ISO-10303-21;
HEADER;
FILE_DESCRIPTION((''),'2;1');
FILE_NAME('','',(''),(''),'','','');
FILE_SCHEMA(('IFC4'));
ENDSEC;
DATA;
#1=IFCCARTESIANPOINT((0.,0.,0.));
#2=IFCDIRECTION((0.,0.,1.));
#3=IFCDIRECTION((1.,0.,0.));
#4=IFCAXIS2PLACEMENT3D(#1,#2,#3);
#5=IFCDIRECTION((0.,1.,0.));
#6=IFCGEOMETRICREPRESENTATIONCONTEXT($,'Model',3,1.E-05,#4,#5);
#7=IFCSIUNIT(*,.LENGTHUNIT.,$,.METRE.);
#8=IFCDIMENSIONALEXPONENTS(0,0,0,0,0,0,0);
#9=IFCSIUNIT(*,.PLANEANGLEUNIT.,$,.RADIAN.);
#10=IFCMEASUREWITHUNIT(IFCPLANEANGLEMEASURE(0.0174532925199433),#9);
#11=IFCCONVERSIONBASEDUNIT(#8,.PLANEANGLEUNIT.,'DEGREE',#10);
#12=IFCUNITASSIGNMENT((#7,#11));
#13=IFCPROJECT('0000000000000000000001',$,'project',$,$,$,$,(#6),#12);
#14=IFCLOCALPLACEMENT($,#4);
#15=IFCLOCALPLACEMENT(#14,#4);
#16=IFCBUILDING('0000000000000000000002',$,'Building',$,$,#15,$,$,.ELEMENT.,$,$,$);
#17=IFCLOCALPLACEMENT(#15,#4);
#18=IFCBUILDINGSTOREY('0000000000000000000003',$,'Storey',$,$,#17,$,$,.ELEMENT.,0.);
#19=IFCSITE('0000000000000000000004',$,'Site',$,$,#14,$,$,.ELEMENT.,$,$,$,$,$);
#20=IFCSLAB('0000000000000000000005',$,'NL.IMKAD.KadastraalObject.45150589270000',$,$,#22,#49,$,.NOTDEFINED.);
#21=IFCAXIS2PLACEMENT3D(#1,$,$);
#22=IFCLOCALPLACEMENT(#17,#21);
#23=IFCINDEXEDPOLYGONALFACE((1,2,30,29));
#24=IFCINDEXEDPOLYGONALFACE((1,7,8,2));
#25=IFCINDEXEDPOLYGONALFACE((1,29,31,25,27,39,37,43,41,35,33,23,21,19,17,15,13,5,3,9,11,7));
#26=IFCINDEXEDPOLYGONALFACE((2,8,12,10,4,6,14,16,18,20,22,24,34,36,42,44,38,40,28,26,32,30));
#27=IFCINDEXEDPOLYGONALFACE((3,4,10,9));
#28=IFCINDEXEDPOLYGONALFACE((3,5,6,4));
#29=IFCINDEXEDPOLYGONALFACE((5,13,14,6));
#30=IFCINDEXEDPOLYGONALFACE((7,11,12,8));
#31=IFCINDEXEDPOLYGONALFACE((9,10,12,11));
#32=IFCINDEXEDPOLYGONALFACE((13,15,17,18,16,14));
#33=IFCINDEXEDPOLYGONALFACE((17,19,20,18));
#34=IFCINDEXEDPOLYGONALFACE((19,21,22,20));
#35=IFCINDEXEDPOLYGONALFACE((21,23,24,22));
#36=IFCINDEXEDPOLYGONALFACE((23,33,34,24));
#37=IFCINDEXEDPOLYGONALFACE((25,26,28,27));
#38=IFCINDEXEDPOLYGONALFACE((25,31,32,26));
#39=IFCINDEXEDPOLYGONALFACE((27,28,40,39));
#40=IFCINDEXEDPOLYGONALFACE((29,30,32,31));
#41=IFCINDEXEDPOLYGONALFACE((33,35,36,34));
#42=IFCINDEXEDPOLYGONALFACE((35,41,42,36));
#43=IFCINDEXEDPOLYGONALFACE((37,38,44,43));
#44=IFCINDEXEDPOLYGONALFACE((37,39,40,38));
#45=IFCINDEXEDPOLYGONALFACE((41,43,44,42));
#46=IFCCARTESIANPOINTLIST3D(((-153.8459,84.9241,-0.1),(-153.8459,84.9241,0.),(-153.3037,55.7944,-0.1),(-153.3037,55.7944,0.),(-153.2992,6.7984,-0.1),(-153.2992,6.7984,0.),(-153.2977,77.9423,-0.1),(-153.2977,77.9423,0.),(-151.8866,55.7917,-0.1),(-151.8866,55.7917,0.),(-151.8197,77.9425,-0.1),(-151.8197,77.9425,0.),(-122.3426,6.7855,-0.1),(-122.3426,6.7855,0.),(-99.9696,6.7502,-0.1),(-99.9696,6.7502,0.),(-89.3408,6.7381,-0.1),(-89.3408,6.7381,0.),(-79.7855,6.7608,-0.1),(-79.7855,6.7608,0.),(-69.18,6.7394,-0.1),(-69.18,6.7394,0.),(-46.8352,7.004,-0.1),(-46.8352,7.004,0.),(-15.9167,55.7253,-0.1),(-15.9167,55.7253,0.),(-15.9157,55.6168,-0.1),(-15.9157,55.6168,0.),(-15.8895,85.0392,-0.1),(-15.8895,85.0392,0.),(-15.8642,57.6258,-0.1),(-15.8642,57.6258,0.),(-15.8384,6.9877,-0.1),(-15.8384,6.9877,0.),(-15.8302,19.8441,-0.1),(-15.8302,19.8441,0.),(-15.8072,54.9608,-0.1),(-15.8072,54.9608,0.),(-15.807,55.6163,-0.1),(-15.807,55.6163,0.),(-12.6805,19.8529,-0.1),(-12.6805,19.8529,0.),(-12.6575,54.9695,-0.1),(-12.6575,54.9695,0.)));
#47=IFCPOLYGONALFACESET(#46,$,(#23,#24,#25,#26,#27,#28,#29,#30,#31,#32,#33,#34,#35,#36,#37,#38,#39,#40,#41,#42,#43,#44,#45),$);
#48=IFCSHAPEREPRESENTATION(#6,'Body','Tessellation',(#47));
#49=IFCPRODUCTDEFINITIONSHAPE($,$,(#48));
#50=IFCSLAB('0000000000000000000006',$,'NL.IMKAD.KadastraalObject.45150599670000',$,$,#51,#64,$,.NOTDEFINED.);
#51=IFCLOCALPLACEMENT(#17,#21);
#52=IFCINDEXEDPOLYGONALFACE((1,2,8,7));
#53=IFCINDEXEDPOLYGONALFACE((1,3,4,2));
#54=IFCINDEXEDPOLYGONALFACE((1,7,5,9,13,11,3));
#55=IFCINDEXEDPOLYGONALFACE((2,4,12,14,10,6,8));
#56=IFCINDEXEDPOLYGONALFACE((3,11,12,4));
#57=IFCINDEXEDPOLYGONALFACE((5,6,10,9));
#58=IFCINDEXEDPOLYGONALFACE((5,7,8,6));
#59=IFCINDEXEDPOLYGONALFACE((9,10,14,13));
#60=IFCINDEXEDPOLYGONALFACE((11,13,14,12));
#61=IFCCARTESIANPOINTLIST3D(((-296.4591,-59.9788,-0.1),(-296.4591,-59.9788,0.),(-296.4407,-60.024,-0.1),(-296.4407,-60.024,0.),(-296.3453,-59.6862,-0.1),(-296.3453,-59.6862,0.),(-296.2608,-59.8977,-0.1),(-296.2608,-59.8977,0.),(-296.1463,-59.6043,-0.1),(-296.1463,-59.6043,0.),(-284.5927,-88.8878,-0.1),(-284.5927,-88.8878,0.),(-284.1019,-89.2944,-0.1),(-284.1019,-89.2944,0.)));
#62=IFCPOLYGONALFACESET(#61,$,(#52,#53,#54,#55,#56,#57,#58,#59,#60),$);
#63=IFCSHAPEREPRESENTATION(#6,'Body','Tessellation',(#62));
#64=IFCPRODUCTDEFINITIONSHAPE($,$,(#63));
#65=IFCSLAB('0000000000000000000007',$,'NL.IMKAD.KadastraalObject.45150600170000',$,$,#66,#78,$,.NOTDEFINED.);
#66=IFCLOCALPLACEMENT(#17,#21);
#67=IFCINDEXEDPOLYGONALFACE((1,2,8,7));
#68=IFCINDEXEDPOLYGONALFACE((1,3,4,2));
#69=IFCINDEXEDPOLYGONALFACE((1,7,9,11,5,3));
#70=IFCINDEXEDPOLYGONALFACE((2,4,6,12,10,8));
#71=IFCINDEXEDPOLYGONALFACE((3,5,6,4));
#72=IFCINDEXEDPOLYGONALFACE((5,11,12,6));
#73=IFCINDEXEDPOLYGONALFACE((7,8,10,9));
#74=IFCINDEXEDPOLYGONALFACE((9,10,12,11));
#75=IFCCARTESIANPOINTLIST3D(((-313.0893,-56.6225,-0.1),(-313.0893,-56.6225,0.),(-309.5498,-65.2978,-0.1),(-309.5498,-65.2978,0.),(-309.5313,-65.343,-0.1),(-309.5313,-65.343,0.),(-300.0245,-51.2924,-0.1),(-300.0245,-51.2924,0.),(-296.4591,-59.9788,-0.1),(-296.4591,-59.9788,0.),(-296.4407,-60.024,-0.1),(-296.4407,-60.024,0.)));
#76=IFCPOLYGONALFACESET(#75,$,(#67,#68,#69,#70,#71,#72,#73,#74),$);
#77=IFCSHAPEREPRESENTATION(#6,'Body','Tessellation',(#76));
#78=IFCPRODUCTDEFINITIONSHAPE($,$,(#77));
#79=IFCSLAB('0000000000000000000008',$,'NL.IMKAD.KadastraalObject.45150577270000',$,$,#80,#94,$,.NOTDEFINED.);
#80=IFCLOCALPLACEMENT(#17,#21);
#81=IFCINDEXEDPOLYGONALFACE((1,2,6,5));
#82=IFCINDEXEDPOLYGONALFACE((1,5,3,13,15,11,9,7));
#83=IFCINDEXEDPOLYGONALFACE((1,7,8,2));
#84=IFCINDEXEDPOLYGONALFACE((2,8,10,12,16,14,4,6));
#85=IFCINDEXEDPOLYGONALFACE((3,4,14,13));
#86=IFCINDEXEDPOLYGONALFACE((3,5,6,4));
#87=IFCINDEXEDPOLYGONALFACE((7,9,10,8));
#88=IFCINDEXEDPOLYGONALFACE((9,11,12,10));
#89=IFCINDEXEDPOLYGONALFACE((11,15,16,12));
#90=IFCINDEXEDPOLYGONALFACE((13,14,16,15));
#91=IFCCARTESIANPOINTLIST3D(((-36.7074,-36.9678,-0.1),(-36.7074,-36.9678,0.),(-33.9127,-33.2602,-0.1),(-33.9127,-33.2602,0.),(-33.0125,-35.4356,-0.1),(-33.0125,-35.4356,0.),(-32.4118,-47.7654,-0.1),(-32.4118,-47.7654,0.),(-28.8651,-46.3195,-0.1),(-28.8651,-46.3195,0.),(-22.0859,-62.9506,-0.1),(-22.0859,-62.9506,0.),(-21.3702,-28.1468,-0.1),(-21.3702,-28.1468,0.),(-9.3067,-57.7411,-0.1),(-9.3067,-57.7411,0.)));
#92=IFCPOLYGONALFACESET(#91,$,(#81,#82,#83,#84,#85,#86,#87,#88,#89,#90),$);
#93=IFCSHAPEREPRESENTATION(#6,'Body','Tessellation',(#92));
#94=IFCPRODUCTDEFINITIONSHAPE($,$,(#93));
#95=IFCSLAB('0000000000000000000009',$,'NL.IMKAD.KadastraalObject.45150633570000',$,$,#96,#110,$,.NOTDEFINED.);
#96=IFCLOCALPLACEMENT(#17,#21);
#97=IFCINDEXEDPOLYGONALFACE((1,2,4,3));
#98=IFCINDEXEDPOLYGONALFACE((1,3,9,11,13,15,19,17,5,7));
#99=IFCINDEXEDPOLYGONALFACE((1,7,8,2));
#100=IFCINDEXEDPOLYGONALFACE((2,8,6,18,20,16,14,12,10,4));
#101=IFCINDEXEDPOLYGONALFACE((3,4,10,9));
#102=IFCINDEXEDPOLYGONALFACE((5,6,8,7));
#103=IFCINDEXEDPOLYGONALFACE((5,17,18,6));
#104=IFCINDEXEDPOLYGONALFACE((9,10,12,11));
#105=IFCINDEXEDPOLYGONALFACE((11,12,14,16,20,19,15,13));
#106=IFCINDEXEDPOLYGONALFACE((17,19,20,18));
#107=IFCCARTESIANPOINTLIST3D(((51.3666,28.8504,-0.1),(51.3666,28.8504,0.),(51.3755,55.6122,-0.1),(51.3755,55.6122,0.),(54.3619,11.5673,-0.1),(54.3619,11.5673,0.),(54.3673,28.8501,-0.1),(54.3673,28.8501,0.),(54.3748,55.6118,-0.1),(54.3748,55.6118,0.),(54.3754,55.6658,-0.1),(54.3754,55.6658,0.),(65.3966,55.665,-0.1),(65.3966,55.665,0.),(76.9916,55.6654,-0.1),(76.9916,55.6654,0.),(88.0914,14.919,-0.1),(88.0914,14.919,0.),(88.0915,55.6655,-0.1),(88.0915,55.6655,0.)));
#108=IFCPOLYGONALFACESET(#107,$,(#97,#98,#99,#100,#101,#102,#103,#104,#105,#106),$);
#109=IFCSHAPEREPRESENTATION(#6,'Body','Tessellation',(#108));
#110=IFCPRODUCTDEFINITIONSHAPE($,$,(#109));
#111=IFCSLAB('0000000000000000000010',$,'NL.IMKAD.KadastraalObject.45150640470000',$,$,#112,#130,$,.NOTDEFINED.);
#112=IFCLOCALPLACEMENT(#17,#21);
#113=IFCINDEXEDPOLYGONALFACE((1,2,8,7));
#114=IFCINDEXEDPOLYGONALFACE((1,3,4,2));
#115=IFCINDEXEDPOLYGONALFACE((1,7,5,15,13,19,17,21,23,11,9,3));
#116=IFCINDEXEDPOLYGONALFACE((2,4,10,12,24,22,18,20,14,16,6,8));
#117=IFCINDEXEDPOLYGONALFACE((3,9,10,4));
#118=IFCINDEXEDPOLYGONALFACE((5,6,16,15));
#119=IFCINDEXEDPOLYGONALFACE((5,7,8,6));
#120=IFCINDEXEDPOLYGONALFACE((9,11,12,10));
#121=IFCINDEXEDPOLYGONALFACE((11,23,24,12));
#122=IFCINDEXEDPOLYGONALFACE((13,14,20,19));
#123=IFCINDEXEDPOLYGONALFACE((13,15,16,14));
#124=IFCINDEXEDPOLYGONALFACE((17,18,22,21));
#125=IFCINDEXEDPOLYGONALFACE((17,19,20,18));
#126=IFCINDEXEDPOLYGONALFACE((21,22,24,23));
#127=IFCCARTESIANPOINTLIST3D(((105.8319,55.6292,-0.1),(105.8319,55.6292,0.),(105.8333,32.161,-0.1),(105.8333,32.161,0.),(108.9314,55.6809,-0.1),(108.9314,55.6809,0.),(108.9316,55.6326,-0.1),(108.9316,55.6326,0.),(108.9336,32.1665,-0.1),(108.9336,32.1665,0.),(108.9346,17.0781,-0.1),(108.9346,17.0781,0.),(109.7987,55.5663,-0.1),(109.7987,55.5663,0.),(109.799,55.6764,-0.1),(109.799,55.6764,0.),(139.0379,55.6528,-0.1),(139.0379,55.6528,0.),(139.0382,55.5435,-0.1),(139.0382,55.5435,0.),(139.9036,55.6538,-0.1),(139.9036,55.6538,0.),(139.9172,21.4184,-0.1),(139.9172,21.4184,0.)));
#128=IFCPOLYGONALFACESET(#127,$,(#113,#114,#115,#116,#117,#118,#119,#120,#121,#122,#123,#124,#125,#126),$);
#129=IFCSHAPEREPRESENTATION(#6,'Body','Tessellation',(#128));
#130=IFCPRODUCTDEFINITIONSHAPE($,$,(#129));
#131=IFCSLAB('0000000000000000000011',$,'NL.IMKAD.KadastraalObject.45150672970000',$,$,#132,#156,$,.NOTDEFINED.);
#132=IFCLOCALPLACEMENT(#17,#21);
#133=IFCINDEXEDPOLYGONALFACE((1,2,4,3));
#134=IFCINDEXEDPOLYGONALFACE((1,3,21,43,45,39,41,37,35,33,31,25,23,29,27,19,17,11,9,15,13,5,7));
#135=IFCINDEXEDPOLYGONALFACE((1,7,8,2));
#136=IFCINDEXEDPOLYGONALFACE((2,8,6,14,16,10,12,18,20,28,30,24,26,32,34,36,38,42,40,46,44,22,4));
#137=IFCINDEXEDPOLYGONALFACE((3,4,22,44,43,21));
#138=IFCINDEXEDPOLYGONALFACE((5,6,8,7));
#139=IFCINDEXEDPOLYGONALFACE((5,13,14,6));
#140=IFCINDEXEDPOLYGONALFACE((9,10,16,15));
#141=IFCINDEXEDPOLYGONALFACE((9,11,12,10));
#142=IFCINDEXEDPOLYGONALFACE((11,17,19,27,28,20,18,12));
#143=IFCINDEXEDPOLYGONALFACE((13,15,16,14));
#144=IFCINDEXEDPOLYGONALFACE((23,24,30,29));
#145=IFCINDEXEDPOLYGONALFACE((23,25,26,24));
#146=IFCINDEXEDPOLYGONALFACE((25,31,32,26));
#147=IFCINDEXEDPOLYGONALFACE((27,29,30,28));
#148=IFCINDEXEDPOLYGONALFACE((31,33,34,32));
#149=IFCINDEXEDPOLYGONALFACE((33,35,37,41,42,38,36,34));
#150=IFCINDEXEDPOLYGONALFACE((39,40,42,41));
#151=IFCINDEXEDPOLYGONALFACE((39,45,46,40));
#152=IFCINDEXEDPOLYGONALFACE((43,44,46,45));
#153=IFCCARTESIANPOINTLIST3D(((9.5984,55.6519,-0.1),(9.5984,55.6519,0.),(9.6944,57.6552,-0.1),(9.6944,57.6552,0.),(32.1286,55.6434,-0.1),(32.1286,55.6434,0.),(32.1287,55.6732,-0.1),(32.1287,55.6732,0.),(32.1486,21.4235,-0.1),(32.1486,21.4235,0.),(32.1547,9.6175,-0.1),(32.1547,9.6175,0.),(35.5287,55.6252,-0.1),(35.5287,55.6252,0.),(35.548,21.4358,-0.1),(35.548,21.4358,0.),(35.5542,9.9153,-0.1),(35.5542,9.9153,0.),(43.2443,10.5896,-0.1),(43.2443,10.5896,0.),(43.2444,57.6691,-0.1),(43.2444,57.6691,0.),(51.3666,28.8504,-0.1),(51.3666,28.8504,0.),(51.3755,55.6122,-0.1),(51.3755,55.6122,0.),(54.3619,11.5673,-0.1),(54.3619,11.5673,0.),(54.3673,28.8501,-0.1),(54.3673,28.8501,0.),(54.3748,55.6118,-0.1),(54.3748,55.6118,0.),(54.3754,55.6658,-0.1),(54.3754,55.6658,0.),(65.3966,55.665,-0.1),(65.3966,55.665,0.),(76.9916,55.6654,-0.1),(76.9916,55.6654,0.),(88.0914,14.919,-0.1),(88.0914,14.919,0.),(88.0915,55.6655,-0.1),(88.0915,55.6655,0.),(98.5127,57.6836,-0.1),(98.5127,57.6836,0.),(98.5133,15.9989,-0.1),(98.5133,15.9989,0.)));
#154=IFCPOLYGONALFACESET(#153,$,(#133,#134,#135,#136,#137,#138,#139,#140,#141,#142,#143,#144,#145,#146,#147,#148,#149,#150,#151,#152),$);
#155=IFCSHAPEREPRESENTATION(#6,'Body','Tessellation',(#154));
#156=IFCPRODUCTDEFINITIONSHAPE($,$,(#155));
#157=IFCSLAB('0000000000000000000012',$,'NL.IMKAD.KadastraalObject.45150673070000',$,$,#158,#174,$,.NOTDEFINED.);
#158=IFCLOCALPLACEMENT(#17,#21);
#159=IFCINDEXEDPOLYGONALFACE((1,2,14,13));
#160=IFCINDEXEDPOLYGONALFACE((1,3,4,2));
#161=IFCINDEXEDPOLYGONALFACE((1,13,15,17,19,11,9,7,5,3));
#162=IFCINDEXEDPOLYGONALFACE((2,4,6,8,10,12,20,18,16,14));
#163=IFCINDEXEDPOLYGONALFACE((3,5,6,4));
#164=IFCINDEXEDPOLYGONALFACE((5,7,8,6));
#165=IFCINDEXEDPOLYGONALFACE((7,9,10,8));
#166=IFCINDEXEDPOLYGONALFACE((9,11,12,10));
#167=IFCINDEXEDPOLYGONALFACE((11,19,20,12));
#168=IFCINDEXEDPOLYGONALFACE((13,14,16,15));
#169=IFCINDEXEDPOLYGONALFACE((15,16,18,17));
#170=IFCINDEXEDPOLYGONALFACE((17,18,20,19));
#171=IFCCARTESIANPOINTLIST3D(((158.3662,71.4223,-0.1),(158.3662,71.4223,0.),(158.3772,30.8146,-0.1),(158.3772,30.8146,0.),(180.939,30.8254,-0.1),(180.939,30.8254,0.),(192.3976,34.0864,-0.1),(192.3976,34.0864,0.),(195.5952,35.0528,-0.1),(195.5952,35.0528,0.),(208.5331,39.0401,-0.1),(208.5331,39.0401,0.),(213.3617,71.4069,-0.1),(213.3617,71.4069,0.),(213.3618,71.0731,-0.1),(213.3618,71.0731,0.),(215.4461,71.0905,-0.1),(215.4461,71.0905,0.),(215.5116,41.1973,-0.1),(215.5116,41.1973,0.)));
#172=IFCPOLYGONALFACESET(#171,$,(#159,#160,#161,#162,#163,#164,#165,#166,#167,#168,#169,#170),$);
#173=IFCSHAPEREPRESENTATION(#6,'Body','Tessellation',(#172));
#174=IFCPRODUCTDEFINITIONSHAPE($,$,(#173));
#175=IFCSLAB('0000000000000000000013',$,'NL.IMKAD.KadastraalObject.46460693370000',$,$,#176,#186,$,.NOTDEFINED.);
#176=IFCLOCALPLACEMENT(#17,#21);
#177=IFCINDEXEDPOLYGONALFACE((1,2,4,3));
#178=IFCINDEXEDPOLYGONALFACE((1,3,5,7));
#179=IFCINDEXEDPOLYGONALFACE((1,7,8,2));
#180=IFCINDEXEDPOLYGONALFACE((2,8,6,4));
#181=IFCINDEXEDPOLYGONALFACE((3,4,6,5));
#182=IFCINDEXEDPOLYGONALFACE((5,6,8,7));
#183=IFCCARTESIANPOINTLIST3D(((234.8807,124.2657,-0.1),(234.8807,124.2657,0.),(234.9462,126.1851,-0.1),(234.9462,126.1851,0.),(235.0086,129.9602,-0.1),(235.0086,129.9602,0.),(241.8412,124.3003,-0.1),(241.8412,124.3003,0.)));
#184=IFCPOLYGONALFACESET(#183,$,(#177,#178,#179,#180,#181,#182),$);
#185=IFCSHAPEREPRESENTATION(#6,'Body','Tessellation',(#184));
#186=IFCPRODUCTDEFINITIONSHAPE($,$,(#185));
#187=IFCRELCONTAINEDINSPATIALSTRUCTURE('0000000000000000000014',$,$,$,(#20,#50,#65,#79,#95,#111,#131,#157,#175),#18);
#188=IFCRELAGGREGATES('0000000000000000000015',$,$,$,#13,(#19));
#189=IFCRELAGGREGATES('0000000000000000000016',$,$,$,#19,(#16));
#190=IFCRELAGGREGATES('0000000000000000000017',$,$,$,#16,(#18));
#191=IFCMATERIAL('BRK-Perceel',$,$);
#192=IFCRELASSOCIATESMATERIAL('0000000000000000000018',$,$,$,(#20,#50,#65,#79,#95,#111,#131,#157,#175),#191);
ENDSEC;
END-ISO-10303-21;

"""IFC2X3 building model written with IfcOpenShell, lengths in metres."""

from ifc_helpers import new_model, entity, si_unit, converted_unit, direction, frame, origin_with_axes, place, context, project, spatial, polyline, outline, extrude, material, element, save


model = new_model("IFC2X3")

# Units and contexts
model_context = context("Model", 3, precision=1e-05, world=origin_with_axes(), true_north=direction((0.0, 1.0, 0.0)))
ifc_project = project(units=[si_unit("LENGTHUNIT", "METRE"), converted_unit("PLANEANGLEUNIT", "DEGREE", entity("IfcPlaneAngleMeasure", 0.0174532925199433), si_unit("PLANEANGLEUNIT", "RADIAN"), dimensions=[0, 0, 0, 0, 0, 0, 0])], contexts=[model_context])

# Site, building, storey
site_placement = place(None, origin_with_axes())
site = spatial("IfcSite", under=ifc_project, at=site_placement, Name="Site", CompositionType="ELEMENT")
building_placement = place(site_placement, origin_with_axes())
building = spatial("IfcBuilding", under=site, at=building_placement, Name="Building", CompositionType="ELEMENT")
storey_placement = place(building_placement, origin_with_axes())
storey = spatial("IfcBuildingStorey", under=building, at=storey_placement, Name="Storey", CompositionType="ELEMENT", Elevation=0.0)

# Slabs
ifc_material = material(Name="BRK-Perceel")
slab_1_placement = place(storey_placement, frame((0.0, 0.0, -0.1), z_axis=(0.0, 0.0, 1.0), x_axis=(1.0, 0.0, 0.0)))
element("IfcSlab", 1, at=slab_1_placement, inside=storey, material=ifc_material, Name="NL.IMKAD.KadastraalObject.45150589270000", PredefinedType="NOTDEFINED", context=model_context, shape_type="SweptSolid", body=[
    extrude(outline(polyline([(-12.6805, 19.8529), (-15.8302, 19.8441), (-15.8384, 6.9877), (-46.8352, 7.004), (-69.18, 6.7394), (-79.7855, 6.7608), (-89.3408, 6.7381), (-99.9696, 6.7502), (-122.3426, 6.7855), (-153.2992, 6.7984), (-153.3037, 55.7944), (-151.8866, 55.7917), (-151.8197, 77.9425), (-153.2977, 77.9423), (-153.8459, 84.9241), (-15.8895, 85.0392), (-15.8642, 57.6258), (-15.9167, 55.7253), (-15.9157, 55.6168), (-15.807, 55.6163), (-15.8072, 54.9608), (-12.6575, 54.9695), (-12.6805, 19.8529)])), origin_with_axes(), (0.0, 0.0, 1.0), 0.1),
])
slab_2_placement = place(storey_placement, frame((0.0, 0.0, -0.1), z_axis=(0.0, 0.0, 1.0), x_axis=(1.0, 0.0, 0.0)))
element("IfcSlab", 2, at=slab_2_placement, inside=storey, material=ifc_material, Name="NL.IMKAD.KadastraalObject.45150599670000", PredefinedType="NOTDEFINED", context=model_context, shape_type="SweptSolid", body=[
    extrude(outline(polyline([(-296.4407, -60.024), (-296.4591, -59.9788), (-296.2608, -59.8977), (-296.3453, -59.6862), (-296.1463, -59.6043), (-284.1019, -89.2944), (-284.5927, -88.8878), (-296.4407, -60.024)])), origin_with_axes(), (0.0, 0.0, 1.0), 0.1),
])
slab_3_placement = place(storey_placement, frame((0.0, 0.0, -0.1), z_axis=(0.0, 0.0, 1.0), x_axis=(1.0, 0.0, 0.0)))
element("IfcSlab", 3, at=slab_3_placement, inside=storey, material=ifc_material, Name="NL.IMKAD.KadastraalObject.45150600170000", PredefinedType="NOTDEFINED", context=model_context, shape_type="SweptSolid", body=[
    extrude(outline(polyline([(-309.5313, -65.343), (-309.5498, -65.2978), (-313.0893, -56.6225), (-300.0245, -51.2924), (-296.4591, -59.9788), (-296.4407, -60.024), (-309.5313, -65.343)])), origin_with_axes(), (0.0, 0.0, 1.0), 0.1),
])
slab_4_placement = place(storey_placement, frame((0.0, 0.0, -0.1), z_axis=(0.0, 0.0, 1.0), x_axis=(1.0, 0.0, 0.0)))
element("IfcSlab", 4, at=slab_4_placement, inside=storey, material=ifc_material, Name="NL.IMKAD.KadastraalObject.45150577270000", PredefinedType="NOTDEFINED", context=model_context, shape_type="SweptSolid", body=[
    extrude(outline(polyline([(-21.3702, -28.1468), (-9.3067, -57.7411), (-22.0859, -62.9506), (-28.8651, -46.3195), (-32.4118, -47.7654), (-36.7074, -36.9678), (-33.0125, -35.4356), (-33.9127, -33.2602), (-21.3702, -28.1468)])), origin_with_axes(), (0.0, 0.0, 1.0), 0.1),
])
slab_5_placement = place(storey_placement, frame((0.0, 0.0, -0.1), z_axis=(0.0, 0.0, 1.0), x_axis=(1.0, 0.0, 0.0)))
element("IfcSlab", 5, at=slab_5_placement, inside=storey, material=ifc_material, Name="NL.IMKAD.KadastraalObject.45150633570000", PredefinedType="NOTDEFINED", context=model_context, shape_type="SweptSolid", body=[
    extrude(outline(polyline([(54.3748, 55.6118), (54.3754, 55.6658), (65.3966, 55.665), (76.9916, 55.6654), (88.0915, 55.6655), (88.0914, 14.919), (54.3619, 11.5673), (54.3673, 28.8501), (51.3666, 28.8504), (51.3755, 55.6122), (54.3748, 55.6118)])), origin_with_axes(), (0.0, 0.0, 1.0), 0.1),
])
slab_6_placement = place(storey_placement, frame((0.0, 0.0, -0.1), z_axis=(0.0, 0.0, 1.0), x_axis=(1.0, 0.0, 0.0)))
element("IfcSlab", 6, at=slab_6_placement, inside=storey, material=ifc_material, Name="NL.IMKAD.KadastraalObject.45150640470000", PredefinedType="NOTDEFINED", context=model_context, shape_type="SweptSolid", body=[
    extrude(outline(polyline([(108.9314, 55.6809), (109.799, 55.6764), (109.7987, 55.5663), (139.0382, 55.5435), (139.0379, 55.6528), (139.9036, 55.6538), (139.9172, 21.4184), (108.9346, 17.0781), (108.9336, 32.1665), (105.8333, 32.161), (105.8319, 55.6292), (108.9316, 55.6326), (108.9314, 55.6809)])), origin_with_axes(), (0.0, 0.0, 1.0), 0.1),
])
slab_7_placement = place(storey_placement, frame((0.0, 0.0, -0.1), z_axis=(0.0, 0.0, 1.0), x_axis=(1.0, 0.0, 0.0)))
element("IfcSlab", 7, at=slab_7_placement, inside=storey, material=ifc_material, Name="NL.IMKAD.KadastraalObject.45150672970000", PredefinedType="NOTDEFINED", context=model_context, shape_type="SweptSolid", body=[
    extrude(outline(polyline([(43.2443, 10.5896), (35.5542, 9.9153), (32.1547, 9.6175), (32.1486, 21.4235), (35.548, 21.4358), (35.5287, 55.6252), (32.1286, 55.6434), (32.1287, 55.6732), (9.5984, 55.6519), (9.6944, 57.6552), (43.2444, 57.6691), (98.5127, 57.6836), (98.5133, 15.9989), (88.0914, 14.919), (88.0915, 55.6655), (76.9916, 55.6654), (65.3966, 55.665), (54.3754, 55.6658), (54.3748, 55.6118), (51.3755, 55.6122), (51.3666, 28.8504), (54.3673, 28.8501), (54.3619, 11.5673), (43.2443, 10.5896)])), origin_with_axes(), (0.0, 0.0, 1.0), 0.1),
])
slab_8_placement = place(storey_placement, frame((0.0, 0.0, -0.1), z_axis=(0.0, 0.0, 1.0), x_axis=(1.0, 0.0, 0.0)))
element("IfcSlab", 8, at=slab_8_placement, inside=storey, material=ifc_material, Name="NL.IMKAD.KadastraalObject.45150673070000", PredefinedType="NOTDEFINED", context=model_context, shape_type="SweptSolid", body=[
    extrude(outline(polyline([(215.4461, 71.0905), (215.5116, 41.1973), (208.5331, 39.0401), (195.5952, 35.0528), (192.3976, 34.0864), (180.939, 30.8254), (158.3772, 30.8146), (158.3662, 71.4223), (213.3617, 71.4069), (213.3618, 71.0731), (215.4461, 71.0905)])), origin_with_axes(), (0.0, 0.0, 1.0), 0.1),
])
slab_9_placement = place(storey_placement, frame((0.0, 0.0, -0.1), z_axis=(0.0, 0.0, 1.0), x_axis=(1.0, 0.0, 0.0)))
element("IfcSlab", 9, at=slab_9_placement, inside=storey, material=ifc_material, Name="NL.IMKAD.KadastraalObject.46460693370000", PredefinedType="NOTDEFINED", context=model_context, shape_type="SweptSolid", body=[
    extrude(outline(polyline([(234.8807, 124.2657), (234.9462, 126.1851), (235.0086, 129.9602), (241.8412, 124.3003), (234.8807, 124.2657)])), origin_with_axes(), (0.0, 0.0, 1.0), 0.1),
])

save(model, "model.ifc")
